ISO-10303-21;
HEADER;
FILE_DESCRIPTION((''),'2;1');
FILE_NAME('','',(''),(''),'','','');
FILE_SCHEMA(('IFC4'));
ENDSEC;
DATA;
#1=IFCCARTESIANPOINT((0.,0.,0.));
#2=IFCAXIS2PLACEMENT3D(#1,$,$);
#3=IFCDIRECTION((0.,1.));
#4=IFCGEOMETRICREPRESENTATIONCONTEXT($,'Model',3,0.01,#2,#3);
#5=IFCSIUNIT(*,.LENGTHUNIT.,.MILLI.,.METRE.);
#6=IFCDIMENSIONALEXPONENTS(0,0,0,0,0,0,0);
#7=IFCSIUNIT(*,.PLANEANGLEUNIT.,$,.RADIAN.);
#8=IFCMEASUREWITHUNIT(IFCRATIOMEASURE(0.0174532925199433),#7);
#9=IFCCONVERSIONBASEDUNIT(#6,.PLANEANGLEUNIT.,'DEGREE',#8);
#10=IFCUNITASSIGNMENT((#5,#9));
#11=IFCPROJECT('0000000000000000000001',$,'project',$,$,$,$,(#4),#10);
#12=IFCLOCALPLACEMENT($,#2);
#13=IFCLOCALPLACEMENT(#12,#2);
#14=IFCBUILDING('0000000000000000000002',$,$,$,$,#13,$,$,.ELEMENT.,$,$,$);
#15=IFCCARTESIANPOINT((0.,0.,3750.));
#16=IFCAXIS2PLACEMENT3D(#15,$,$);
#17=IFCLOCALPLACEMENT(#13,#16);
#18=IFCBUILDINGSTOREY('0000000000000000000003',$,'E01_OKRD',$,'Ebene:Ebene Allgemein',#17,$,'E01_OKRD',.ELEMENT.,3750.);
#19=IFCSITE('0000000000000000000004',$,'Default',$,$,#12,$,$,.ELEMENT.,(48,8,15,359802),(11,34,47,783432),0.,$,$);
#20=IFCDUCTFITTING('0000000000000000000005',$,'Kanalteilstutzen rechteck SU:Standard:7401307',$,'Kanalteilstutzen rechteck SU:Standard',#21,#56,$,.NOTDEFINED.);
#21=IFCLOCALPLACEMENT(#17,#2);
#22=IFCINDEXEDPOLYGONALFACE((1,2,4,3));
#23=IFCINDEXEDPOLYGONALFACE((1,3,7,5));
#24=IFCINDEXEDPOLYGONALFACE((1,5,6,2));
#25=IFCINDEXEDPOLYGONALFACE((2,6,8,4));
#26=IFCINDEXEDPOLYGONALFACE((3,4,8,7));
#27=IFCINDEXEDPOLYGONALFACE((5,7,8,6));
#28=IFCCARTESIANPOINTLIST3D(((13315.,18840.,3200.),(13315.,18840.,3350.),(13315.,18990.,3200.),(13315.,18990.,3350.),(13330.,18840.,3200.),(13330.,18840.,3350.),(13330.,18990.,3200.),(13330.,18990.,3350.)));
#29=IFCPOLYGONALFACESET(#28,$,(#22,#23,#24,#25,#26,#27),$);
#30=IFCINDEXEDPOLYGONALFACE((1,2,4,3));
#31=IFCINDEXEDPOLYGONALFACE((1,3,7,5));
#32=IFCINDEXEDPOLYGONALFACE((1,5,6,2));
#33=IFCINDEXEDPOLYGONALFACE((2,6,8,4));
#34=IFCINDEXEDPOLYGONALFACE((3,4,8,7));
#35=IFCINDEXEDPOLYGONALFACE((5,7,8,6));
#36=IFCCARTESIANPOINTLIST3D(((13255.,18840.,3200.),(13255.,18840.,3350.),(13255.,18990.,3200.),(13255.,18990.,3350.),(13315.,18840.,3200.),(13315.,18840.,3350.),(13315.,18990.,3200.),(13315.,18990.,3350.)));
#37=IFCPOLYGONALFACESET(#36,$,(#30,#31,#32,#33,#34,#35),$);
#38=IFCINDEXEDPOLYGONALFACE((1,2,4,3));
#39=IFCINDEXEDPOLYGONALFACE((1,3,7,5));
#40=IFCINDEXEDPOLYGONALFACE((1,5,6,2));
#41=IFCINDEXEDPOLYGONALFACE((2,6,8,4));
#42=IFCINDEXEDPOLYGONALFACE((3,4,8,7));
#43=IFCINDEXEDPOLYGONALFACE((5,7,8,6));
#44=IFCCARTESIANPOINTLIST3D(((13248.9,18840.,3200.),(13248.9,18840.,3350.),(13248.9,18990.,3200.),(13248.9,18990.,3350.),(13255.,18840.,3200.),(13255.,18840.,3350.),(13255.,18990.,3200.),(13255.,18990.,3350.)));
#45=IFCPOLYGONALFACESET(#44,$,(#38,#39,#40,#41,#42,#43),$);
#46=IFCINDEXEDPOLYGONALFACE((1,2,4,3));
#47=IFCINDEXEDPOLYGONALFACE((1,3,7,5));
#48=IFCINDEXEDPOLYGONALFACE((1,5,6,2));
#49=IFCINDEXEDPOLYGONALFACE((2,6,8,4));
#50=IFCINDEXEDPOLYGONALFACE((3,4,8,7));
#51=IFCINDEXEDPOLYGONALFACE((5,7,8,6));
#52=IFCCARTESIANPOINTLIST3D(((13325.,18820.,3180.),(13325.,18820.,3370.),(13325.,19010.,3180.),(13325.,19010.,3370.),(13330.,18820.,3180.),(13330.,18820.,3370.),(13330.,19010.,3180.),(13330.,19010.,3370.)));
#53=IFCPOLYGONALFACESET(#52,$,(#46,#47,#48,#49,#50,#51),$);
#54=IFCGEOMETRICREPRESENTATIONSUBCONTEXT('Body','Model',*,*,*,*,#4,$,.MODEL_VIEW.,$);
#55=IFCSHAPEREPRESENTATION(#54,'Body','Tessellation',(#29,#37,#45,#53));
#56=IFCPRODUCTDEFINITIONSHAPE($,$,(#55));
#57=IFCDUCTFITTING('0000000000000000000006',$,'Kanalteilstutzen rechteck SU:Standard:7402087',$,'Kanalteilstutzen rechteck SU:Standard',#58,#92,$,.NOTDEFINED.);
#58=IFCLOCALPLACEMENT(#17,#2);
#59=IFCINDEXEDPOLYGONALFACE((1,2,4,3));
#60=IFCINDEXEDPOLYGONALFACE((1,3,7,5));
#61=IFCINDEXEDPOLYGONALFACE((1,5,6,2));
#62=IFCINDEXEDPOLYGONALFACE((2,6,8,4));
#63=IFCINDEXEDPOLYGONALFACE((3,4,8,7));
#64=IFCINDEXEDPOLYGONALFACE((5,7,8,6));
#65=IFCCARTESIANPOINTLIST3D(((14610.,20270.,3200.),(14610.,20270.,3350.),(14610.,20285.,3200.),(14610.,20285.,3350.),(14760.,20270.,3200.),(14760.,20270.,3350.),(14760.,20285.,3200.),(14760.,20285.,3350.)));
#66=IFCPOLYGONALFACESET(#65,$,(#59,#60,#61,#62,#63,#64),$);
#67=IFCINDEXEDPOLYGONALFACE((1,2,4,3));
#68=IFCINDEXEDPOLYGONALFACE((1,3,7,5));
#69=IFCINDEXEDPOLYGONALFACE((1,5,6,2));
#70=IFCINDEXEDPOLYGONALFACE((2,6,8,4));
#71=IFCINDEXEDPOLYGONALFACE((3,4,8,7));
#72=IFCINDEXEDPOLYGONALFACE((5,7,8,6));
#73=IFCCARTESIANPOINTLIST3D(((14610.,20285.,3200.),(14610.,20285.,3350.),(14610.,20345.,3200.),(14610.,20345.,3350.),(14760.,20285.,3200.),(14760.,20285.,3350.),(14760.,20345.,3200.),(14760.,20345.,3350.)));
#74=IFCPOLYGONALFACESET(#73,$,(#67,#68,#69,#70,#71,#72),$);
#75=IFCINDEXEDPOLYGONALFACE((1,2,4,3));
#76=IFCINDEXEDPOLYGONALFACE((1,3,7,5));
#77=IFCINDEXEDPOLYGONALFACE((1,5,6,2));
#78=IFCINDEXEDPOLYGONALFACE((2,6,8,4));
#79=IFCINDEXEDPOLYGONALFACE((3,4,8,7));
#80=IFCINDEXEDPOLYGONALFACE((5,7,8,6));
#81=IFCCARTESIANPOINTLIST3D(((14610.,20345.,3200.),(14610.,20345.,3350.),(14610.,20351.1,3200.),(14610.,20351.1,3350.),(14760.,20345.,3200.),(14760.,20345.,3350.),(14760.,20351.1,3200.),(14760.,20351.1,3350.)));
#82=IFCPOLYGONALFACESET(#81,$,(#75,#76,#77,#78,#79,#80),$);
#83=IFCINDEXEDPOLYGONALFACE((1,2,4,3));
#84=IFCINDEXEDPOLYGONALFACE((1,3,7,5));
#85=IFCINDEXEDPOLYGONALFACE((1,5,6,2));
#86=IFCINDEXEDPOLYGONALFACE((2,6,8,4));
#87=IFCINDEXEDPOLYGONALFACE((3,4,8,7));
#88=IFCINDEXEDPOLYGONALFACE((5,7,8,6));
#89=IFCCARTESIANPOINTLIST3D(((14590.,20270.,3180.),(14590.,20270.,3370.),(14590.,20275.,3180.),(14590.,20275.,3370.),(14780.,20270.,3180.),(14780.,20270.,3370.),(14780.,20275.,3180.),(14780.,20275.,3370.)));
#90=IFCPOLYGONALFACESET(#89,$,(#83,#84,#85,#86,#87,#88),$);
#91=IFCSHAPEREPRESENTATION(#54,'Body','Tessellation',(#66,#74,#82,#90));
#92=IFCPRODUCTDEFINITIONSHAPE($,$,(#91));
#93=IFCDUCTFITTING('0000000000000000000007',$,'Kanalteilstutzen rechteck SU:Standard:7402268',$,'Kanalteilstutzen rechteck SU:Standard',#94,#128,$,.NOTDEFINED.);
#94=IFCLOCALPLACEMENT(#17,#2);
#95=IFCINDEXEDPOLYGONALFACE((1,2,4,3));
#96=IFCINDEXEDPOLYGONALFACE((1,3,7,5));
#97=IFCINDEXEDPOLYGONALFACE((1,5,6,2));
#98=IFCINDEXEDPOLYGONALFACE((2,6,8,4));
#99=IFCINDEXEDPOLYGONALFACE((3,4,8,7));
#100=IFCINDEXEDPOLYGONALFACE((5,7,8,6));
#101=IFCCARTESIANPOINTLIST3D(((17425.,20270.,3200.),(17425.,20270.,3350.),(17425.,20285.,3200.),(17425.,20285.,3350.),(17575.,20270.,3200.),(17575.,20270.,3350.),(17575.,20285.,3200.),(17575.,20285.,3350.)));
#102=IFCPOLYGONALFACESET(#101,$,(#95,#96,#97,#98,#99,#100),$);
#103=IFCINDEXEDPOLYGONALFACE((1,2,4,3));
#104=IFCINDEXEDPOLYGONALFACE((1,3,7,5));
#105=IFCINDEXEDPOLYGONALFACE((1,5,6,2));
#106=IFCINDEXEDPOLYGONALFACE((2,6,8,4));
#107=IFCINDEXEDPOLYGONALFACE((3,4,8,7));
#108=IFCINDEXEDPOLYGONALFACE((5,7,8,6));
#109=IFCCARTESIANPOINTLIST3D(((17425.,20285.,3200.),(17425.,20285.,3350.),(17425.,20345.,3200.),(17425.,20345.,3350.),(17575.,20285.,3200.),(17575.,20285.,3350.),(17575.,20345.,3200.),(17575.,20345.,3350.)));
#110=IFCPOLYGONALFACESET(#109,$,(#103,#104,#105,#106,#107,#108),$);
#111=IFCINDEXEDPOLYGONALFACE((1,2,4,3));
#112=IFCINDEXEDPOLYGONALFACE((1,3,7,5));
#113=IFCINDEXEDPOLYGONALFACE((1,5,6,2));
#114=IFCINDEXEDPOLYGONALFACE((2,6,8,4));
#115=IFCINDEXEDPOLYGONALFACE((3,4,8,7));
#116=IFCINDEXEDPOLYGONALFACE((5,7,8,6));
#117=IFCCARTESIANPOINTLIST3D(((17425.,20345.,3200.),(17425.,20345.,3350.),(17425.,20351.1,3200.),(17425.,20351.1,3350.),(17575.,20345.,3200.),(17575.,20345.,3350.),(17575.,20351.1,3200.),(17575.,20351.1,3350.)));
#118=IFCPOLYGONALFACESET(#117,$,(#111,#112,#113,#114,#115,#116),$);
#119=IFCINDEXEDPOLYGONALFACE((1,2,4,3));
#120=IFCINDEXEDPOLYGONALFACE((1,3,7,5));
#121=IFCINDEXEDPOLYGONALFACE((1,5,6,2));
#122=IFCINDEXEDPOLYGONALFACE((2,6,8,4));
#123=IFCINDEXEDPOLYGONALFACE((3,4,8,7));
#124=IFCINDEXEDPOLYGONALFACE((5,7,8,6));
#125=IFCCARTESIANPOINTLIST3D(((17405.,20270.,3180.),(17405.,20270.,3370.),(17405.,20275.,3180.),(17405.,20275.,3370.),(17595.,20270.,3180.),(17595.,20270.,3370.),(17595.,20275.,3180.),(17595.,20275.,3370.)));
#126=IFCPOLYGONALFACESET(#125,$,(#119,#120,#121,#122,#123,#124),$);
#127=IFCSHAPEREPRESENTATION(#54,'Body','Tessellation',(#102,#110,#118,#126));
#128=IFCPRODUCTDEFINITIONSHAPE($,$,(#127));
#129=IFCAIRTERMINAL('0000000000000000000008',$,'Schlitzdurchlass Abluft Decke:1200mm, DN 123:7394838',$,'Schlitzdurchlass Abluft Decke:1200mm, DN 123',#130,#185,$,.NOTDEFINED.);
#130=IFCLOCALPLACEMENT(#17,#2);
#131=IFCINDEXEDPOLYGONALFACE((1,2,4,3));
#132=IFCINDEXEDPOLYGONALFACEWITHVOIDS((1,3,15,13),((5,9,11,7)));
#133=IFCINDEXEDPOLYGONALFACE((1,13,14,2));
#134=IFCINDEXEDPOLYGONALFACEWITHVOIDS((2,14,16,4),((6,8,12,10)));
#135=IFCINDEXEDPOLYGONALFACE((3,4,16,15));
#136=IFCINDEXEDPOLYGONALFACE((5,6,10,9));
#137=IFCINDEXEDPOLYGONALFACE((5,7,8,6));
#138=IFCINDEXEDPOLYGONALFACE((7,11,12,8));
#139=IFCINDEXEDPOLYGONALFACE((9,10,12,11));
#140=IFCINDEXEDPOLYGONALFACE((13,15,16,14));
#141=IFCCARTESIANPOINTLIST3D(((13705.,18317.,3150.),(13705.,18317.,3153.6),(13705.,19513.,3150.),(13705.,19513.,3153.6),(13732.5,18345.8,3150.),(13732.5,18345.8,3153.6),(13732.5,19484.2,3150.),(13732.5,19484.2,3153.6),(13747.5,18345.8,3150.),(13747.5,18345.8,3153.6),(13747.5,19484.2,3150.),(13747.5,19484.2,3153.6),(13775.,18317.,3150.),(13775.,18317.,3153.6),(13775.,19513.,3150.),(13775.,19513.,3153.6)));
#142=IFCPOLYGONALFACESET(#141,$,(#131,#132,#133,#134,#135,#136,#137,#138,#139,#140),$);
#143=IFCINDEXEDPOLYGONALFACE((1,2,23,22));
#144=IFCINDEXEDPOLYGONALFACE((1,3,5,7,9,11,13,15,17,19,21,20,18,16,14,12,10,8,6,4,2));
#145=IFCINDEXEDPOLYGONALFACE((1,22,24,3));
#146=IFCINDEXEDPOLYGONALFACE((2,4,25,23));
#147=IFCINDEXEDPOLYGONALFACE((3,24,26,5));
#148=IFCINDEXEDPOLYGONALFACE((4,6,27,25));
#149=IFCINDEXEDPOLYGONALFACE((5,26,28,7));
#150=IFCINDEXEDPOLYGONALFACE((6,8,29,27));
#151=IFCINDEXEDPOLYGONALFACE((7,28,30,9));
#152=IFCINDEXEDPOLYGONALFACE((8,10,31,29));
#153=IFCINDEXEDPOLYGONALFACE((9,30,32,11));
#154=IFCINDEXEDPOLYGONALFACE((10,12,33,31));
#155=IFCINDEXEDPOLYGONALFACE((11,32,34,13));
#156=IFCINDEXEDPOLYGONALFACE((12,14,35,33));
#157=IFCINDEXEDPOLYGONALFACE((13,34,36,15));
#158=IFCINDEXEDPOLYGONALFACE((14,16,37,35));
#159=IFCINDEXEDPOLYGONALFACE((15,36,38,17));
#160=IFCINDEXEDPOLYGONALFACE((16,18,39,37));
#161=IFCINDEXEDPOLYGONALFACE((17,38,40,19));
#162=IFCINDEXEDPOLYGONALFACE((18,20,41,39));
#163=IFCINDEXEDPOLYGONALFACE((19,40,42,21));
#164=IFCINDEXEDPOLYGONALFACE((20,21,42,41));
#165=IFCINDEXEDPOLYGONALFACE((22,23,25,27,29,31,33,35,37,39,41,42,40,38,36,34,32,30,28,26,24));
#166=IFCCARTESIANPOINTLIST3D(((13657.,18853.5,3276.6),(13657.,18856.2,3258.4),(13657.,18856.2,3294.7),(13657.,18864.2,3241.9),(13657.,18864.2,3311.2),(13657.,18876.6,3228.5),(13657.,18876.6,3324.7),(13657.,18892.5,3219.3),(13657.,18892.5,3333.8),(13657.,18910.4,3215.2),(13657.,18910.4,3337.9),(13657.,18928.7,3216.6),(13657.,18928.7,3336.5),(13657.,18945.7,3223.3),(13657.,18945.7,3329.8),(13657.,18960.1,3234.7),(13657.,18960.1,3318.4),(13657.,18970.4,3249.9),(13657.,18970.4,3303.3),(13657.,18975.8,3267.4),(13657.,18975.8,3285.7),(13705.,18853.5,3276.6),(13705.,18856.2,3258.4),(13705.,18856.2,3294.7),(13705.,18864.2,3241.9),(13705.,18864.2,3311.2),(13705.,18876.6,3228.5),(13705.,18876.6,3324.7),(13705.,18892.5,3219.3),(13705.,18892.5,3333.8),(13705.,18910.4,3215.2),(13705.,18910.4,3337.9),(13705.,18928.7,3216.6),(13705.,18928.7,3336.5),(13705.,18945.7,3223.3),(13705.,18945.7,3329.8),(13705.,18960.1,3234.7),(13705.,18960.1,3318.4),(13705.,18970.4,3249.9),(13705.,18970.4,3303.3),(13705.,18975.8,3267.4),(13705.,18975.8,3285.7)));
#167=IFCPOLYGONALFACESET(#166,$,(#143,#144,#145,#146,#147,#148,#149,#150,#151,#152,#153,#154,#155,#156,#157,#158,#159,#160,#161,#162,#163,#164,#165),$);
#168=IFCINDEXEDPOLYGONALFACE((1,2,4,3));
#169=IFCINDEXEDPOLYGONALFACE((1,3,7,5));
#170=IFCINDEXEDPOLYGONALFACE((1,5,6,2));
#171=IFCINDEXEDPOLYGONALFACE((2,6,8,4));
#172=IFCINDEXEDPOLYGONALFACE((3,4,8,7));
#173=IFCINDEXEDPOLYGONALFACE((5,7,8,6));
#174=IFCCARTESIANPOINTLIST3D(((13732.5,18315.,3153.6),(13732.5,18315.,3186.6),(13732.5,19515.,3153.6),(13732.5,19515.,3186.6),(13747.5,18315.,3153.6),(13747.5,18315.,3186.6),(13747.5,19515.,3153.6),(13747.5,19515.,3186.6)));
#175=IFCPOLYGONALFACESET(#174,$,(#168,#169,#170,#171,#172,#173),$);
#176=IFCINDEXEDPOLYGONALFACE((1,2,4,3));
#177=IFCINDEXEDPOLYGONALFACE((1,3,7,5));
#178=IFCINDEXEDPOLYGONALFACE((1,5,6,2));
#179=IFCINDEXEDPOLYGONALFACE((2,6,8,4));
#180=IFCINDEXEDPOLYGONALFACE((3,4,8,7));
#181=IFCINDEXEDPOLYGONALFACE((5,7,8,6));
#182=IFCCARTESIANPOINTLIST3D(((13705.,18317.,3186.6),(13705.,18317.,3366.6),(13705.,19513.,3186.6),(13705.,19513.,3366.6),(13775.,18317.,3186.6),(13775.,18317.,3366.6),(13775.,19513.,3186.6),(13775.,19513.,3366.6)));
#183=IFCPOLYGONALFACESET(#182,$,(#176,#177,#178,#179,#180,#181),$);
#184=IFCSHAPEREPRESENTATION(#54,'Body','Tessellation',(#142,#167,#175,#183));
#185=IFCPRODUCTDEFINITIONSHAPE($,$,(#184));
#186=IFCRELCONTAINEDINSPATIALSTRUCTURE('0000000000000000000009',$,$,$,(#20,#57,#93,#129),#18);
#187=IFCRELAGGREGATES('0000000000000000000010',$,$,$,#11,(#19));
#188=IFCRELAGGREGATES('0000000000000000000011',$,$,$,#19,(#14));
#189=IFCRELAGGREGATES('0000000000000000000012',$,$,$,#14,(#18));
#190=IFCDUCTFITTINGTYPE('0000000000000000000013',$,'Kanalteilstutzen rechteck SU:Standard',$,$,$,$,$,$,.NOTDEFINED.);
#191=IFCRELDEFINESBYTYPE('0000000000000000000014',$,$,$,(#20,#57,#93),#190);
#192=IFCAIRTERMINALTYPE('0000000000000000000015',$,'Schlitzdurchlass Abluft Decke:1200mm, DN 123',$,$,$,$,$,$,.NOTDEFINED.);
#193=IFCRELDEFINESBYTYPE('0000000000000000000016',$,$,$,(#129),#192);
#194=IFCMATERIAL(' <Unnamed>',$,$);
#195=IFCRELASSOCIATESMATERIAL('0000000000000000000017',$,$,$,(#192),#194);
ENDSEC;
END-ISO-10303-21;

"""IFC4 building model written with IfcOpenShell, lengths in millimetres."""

from ifc_helpers import new_model, entity, si_unit, converted_unit, direction, frame, frame_2d, origin, origin_2d_with_axis, place, context, subcontext, project, spatial, polyline, rectangle, circle, outline, extrude, source, transform, mapped, material, type_object, type_shapes, element, save


model = new_model("IFC4")

# Units and contexts
model_context = context("Model", 3, precision=0.01, world=origin(), true_north=direction((0.0, 1.0)))
body_context = subcontext(model_context, "Body", "Model", "MODEL_VIEW")
ifc_project = project(units=[si_unit("LENGTHUNIT", "METRE", prefix="MILLI"), converted_unit("PLANEANGLEUNIT", "DEGREE", entity("IfcRatioMeasure", 0.0174532925199433), si_unit("PLANEANGLEUNIT", "RADIAN"), dimensions=[0, 0, 0, 0, 0, 0, 0])], contexts=[model_context])

# Site, building, storey
site_placement = place(None, origin())
site = spatial("IfcSite", under=ifc_project, at=site_placement, Name="Default", CompositionType="ELEMENT", RefLatitude=(48, 8, 15, 359802), RefLongitude=(11, 34, 47, 783432), RefElevation=0.0)
building_placement = place(site_placement, origin())
building = spatial("IfcBuilding", under=site, at=building_placement, CompositionType="ELEMENT")
storey_placement = place(building_placement, frame((0.0, 0.0, 3750.0)))
storey = spatial("IfcBuildingStorey", under=building, at=storey_placement, Name="E01_OKRD", ObjectType="Ebene:Ebene Allgemein", LongName="E01_OKRD", CompositionType="ELEMENT", Elevation=3750.0)

# Shared definitions
ifc_material_1 = material(Name=" <Unnamed>")

# Duct fittings
duct_fitting_type_1 = type_object("IfcDuctFittingType", Name="Kanalteilstutzen rechteck SU:Standard", PredefinedType="NOTDEFINED")
shared_shape_1 = source(origin(), body_context, "Body", "SweptSolid", [
    extrude(rectangle(XDim=15.0, YDim=150.0, at=frame_2d((0.0, 0.0), x_axis=(1.0, 0.0))), frame((67.5, 0.0, -75.0)), (0.0, 0.0, 1.0), 150.0),
    extrude(rectangle(XDim=60.0, YDim=150.0, at=frame_2d((0.0, 0.0), x_axis=(1.0, 0.0))), frame((30.0, 0.0, -75.0)), (0.0, 0.0, 1.0), 150.0),
    extrude(rectangle(XDim=6.1, YDim=150.0, at=frame_2d((0.0, 0.0), x_axis=(1.0, 0.0))), frame((-3.0, 0.0, -75.0)), (0.0, 0.0, 1.0), 150.0),
    extrude(rectangle(XDim=5.0, YDim=190.0, at=origin_2d_with_axis()), frame((72.5, 0.0, -95.0)), (0.0, 0.0, 1.0), 190.0),
])
type_shapes(duct_fitting_type_1, [shared_shape_1])
for number, where, z_axis, x_axis, name in (
    (1, (13255.0, 18915.0, 3275.0), (0.0, 0.0, -1.0), (1.0, 0.0, 0.0), "Kanalteilstutzen rechteck SU:Standard:7401307"),
    (2, (14685.0, 20345.0, 3275.0), (0.0, 0.0, -1.0), (0.0, -1.0, 0.0), "Kanalteilstutzen rechteck SU:Standard:7402087"),
    (3, (17500.0, 20345.0, 3275.0), (0.0, 0.0, -1.0), (0.0, -1.0, 0.0), "Kanalteilstutzen rechteck SU:Standard:7402268"),
):
    element("IfcDuctFitting", number, at=place(storey_placement, frame(where, z_axis=z_axis, x_axis=x_axis)), inside=storey, type_object=duct_fitting_type_1, Name=name, ObjectType="Kanalteilstutzen rechteck SU:Standard", PredefinedType="NOTDEFINED", context=body_context, shape_type="MappedRepresentation", body=[
        mapped(shared_shape_1, transform((0.0, 0.0, 0.0), scale=1.0)),
    ])

# Air terminal
air_terminal_type_1 = type_object("IfcAirTerminalType", Name="Schlitzdurchlass Abluft Decke:1200mm, DN 123", PredefinedType="NOTDEFINED", material=ifc_material_1)
shared_shape_2 = source(origin(), body_context, "Body", "SweptSolid", [
    extrude(outline(polyline([(-598.0, -35.0), (598.0, -35.0), (598.0, 35.0), (-598.0, 35.0), (-598.0, -35.0)]), holes=[polyline([(-569.2, -7.5), (-569.2, 7.5), (569.2, 7.5), (569.2, -7.5), (-569.2, -7.5)])]), frame((0.0, 0.0, 0.0), z_axis=(0.0, 0.0, 1.0), x_axis=(-1.0, 0.0, 0.0)), (0.0, 0.0, 1.0), 3.6),
    extrude(circle(Radius=61.5, at=frame_2d((0.0, 0.0), x_axis=(1.0, 0.0))), frame((0.0, 35.0, 126.6), z_axis=(0.0, 1.0, 0.0), x_axis=(-1.0, 0.0, 0.0)), (0.0, 0.0, 1.0), 48.0),
    extrude(rectangle(XDim=1200.0, YDim=15.0, at=origin_2d_with_axis()), frame((0.0, 0.0, 3.6), z_axis=(0.0, 0.0, 1.0), x_axis=(-1.0, 0.0, 0.0)), (0.0, 0.0, 1.0), 33.0),
    extrude(rectangle(XDim=1196.0, YDim=70.0, at=origin_2d_with_axis()), frame((0.0, 0.0, 36.6), z_axis=(0.0, 0.0, 1.0), x_axis=(-1.0, 0.0, 0.0)), (0.0, 0.0, 1.0), 180.0),
])
type_shapes(air_terminal_type_1, [shared_shape_2])
for number, where, z_axis, x_axis, name in (
    (4, (13740.0, 18915.0, 3150.0), (0.0, 0.0, 1.0), (0.0, 1.0, 0.0), "Schlitzdurchlass Abluft Decke:1200mm, DN 123:7394838"),
):
    element("IfcAirTerminal", number, at=place(storey_placement, frame(where, z_axis=z_axis, x_axis=x_axis)), inside=storey, type_object=air_terminal_type_1, Name=name, ObjectType="Schlitzdurchlass Abluft Decke:1200mm, DN 123", PredefinedType="NOTDEFINED", context=body_context, shape_type="MappedRepresentation", body=[
        mapped(shared_shape_2, transform((0.0, 0.0, 0.0), scale=1.0)),
    ])

save(model, "model.ifc")
